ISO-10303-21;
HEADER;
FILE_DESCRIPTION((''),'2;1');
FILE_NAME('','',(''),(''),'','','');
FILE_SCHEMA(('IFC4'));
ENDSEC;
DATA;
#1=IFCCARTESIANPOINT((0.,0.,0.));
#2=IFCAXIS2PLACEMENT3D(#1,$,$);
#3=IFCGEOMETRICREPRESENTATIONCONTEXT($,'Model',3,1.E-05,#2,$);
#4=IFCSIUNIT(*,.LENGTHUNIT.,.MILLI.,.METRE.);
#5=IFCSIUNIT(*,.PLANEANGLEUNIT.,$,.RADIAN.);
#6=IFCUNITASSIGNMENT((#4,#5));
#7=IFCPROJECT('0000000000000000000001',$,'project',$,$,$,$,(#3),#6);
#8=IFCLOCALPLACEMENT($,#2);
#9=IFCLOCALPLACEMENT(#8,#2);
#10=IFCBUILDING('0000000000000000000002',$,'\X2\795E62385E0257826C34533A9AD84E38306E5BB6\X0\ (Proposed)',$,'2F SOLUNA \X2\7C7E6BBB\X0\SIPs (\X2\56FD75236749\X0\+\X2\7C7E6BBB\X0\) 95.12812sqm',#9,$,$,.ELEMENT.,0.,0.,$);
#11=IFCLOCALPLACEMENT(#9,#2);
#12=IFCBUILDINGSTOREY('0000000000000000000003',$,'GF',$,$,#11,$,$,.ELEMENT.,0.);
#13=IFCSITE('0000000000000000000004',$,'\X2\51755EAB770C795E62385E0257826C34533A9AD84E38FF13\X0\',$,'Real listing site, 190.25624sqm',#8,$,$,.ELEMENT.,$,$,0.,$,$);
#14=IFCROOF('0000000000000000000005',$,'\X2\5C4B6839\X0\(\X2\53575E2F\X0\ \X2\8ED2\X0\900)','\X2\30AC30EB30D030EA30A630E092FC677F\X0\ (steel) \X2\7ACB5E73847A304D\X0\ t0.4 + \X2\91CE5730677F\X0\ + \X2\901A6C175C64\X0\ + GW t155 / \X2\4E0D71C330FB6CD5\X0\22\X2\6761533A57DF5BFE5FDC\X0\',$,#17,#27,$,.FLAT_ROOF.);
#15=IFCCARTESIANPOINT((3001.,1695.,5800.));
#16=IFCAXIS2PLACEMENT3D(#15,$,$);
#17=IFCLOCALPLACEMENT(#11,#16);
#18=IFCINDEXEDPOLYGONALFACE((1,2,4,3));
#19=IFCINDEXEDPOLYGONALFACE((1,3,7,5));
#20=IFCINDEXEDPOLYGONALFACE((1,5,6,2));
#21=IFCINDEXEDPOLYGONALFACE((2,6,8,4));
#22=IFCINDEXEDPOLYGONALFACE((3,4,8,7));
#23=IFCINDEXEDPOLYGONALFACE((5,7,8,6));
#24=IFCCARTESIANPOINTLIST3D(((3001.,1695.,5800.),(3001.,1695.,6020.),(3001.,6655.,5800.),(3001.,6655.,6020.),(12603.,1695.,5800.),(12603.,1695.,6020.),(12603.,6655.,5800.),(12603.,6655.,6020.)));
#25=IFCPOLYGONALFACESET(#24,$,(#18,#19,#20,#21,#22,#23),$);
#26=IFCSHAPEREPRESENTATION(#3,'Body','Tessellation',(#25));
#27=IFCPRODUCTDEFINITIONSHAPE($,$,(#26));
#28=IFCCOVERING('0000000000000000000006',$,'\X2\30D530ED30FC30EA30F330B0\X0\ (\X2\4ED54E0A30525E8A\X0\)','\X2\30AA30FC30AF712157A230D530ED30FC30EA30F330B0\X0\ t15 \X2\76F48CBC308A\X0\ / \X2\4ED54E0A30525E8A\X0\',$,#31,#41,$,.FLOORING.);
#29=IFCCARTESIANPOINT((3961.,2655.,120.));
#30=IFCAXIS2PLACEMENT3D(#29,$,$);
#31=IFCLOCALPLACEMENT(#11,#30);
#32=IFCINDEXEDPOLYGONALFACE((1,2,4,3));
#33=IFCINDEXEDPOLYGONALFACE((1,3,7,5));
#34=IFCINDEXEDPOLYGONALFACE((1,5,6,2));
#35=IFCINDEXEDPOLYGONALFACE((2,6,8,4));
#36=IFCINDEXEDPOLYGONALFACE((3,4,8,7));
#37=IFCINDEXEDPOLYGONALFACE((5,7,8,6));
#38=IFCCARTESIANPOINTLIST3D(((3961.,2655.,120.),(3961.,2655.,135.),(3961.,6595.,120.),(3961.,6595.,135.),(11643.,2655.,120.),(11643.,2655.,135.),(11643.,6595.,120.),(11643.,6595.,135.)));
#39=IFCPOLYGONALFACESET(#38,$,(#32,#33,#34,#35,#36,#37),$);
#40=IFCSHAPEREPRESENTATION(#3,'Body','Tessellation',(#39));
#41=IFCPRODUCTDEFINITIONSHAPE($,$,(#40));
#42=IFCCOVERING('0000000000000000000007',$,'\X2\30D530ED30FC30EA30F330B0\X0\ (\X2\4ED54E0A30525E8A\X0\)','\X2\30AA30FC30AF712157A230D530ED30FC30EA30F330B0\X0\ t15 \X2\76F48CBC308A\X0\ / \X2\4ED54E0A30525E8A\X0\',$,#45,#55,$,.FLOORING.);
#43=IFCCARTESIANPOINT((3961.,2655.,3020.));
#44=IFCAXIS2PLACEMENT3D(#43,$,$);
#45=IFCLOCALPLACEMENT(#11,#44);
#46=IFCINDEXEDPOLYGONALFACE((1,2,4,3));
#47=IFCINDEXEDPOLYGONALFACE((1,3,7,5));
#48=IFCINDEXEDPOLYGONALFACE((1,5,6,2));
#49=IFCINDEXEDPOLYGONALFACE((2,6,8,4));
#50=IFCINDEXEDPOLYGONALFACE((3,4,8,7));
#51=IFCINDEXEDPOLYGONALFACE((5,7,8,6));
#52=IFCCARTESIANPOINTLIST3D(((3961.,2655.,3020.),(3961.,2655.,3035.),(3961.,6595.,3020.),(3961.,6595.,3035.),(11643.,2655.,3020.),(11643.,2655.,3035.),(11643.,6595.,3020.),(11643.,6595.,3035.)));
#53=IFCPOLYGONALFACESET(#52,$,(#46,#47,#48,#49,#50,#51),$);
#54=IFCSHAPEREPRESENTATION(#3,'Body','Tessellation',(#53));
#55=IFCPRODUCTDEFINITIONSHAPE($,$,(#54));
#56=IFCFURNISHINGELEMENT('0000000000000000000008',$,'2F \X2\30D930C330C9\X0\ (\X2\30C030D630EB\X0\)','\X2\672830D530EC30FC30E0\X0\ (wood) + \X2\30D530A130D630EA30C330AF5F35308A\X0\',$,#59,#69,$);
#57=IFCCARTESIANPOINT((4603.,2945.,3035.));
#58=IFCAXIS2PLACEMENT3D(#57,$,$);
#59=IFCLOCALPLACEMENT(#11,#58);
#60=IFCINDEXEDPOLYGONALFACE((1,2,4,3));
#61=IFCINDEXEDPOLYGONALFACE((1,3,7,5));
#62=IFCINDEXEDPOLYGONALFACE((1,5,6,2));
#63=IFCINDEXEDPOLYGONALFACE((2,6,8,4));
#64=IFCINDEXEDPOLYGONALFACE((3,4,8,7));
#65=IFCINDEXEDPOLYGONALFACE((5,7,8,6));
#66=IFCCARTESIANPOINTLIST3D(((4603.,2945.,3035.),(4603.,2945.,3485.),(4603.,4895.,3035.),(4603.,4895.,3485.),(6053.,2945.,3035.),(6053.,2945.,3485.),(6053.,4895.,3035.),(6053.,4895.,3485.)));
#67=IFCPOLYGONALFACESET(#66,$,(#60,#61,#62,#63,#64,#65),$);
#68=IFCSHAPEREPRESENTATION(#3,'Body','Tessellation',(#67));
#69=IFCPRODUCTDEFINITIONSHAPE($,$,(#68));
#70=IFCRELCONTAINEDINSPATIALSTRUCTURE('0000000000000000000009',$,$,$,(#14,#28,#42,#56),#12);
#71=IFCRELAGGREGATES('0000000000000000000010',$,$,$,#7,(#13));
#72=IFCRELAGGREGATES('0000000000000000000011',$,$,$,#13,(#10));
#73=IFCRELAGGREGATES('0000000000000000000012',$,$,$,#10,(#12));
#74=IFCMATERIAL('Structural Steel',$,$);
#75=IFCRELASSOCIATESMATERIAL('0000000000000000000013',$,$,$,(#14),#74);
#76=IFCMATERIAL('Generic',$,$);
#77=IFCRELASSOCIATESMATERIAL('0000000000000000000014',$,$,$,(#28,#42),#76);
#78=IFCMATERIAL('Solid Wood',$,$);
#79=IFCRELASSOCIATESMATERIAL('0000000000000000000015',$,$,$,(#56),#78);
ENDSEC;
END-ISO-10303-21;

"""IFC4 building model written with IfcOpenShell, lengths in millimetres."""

from ifc_helpers import new_model, si_unit, frame, frame_2d, origin, place, context, project, spatial, rectangle, extrude, material, element, save


model = new_model("IFC4")

# Units and contexts
model_context = context("Model", 3, precision=1e-05, world=origin())
ifc_project = project(units=[si_unit("LENGTHUNIT", "METRE", prefix="MILLI"), si_unit("PLANEANGLEUNIT", "RADIAN")], contexts=[model_context])

# Site, building, storey
site_placement = place(None, origin())
site = spatial("IfcSite", under=ifc_project, at=site_placement, Name="兵庫県神戸市垂水区高丸３", ObjectType="Real listing site, 190.25624sqm", CompositionType="ELEMENT", RefElevation=0.0)
building_placement = place(site_placement, origin())
building = spatial("IfcBuilding", under=site, at=building_placement, Name="神戸市垂水区高丸の家 (Proposed)", ObjectType="2F SOLUNA 籾殻SIPs (国産杉+籾殻) 95.12812sqm", CompositionType="ELEMENT", ElevationOfRefHeight=0.0, ElevationOfTerrain=0.0)
storey_placement = place(building_placement, origin())
storey = spatial("IfcBuildingStorey", under=building, at=storey_placement, Name="GF", CompositionType="ELEMENT", Elevation=0.0)

# Shared definitions
ifc_material_1 = material(Name="Solid Wood")

# Roof
ifc_material_2 = material(Name="Structural Steel")
for number, where, name in (
    (1, (3001.0, 1695.0, 5800.0), "屋根(南帯 軒900)"),
):
    element("IfcRoof", number, at=place(storey_placement, frame(where)), inside=storey, material=ifc_material_2, Name=name, Description="ガルバリウム鋼板 (steel) 立平葺き t0.4 + 野地板 + 通気層 + GW t155 / 不燃・法22条区域対応", PredefinedType="FLAT_ROOF", context=model_context, shape_type="SweptSolid", body=[
        extrude(rectangle(XDim=9602.0, YDim=4960.0, at=frame_2d((4801.0, 2480.0))), frame((3001.0, 1695.0, 5800.0)), (0.0, 0.0, 1.0), 220.0),
    ])

# Coverings
ifc_material_3 = material(Name="Generic")
covering_1_placement = place(storey_placement, frame((3961.0, 2655.0, 120.0)))
element("IfcCovering", 2, at=covering_1_placement, inside=storey, material=ifc_material_3, Name="フローリング (仕上げ床)", Description="オーク無垢フローリング t15 直貼り / 仕上げ床", PredefinedType="FLOORING", context=model_context, shape_type="SweptSolid", body=[
    extrude(rectangle(XDim=7682.0, YDim=3940.0, at=frame_2d((3841.0, 1970.0))), frame((3961.0, 2655.0, 120.0)), (0.0, 0.0, 1.0), 15.0),
])
covering_2_placement = place(storey_placement, frame((3961.0, 2655.0, 3020.0)))
element("IfcCovering", 3, at=covering_2_placement, inside=storey, material=ifc_material_3, Name="フローリング (仕上げ床)", Description="オーク無垢フローリング t15 直貼り / 仕上げ床", PredefinedType="FLOORING", context=model_context, shape_type="SweptSolid", body=[
    extrude(rectangle(XDim=7682.0, YDim=3940.0, at=frame_2d((3841.0, 1970.0))), frame((3961.0, 2655.0, 3020.0)), (0.0, 0.0, 1.0), 15.0),
])

# Furnishing element
furnishing_placement = place(storey_placement, frame((4603.0, 2945.0, 3035.0)))
element("IfcFurnishingElement", 4, at=furnishing_placement, inside=storey, material=ifc_material_1, Name="2F ベッド (ダブル)", Description="木フレーム (wood) + ファブリック張り", context=model_context, shape_type="SweptSolid", body=[
    extrude(rectangle(XDim=1450.0, YDim=1950.0, at=frame_2d((725.0, 975.0))), frame((4603.0, 2945.0, 3035.0)), (0.0, 0.0, 1.0), 450.0),
])

save(model, "model.ifc")
